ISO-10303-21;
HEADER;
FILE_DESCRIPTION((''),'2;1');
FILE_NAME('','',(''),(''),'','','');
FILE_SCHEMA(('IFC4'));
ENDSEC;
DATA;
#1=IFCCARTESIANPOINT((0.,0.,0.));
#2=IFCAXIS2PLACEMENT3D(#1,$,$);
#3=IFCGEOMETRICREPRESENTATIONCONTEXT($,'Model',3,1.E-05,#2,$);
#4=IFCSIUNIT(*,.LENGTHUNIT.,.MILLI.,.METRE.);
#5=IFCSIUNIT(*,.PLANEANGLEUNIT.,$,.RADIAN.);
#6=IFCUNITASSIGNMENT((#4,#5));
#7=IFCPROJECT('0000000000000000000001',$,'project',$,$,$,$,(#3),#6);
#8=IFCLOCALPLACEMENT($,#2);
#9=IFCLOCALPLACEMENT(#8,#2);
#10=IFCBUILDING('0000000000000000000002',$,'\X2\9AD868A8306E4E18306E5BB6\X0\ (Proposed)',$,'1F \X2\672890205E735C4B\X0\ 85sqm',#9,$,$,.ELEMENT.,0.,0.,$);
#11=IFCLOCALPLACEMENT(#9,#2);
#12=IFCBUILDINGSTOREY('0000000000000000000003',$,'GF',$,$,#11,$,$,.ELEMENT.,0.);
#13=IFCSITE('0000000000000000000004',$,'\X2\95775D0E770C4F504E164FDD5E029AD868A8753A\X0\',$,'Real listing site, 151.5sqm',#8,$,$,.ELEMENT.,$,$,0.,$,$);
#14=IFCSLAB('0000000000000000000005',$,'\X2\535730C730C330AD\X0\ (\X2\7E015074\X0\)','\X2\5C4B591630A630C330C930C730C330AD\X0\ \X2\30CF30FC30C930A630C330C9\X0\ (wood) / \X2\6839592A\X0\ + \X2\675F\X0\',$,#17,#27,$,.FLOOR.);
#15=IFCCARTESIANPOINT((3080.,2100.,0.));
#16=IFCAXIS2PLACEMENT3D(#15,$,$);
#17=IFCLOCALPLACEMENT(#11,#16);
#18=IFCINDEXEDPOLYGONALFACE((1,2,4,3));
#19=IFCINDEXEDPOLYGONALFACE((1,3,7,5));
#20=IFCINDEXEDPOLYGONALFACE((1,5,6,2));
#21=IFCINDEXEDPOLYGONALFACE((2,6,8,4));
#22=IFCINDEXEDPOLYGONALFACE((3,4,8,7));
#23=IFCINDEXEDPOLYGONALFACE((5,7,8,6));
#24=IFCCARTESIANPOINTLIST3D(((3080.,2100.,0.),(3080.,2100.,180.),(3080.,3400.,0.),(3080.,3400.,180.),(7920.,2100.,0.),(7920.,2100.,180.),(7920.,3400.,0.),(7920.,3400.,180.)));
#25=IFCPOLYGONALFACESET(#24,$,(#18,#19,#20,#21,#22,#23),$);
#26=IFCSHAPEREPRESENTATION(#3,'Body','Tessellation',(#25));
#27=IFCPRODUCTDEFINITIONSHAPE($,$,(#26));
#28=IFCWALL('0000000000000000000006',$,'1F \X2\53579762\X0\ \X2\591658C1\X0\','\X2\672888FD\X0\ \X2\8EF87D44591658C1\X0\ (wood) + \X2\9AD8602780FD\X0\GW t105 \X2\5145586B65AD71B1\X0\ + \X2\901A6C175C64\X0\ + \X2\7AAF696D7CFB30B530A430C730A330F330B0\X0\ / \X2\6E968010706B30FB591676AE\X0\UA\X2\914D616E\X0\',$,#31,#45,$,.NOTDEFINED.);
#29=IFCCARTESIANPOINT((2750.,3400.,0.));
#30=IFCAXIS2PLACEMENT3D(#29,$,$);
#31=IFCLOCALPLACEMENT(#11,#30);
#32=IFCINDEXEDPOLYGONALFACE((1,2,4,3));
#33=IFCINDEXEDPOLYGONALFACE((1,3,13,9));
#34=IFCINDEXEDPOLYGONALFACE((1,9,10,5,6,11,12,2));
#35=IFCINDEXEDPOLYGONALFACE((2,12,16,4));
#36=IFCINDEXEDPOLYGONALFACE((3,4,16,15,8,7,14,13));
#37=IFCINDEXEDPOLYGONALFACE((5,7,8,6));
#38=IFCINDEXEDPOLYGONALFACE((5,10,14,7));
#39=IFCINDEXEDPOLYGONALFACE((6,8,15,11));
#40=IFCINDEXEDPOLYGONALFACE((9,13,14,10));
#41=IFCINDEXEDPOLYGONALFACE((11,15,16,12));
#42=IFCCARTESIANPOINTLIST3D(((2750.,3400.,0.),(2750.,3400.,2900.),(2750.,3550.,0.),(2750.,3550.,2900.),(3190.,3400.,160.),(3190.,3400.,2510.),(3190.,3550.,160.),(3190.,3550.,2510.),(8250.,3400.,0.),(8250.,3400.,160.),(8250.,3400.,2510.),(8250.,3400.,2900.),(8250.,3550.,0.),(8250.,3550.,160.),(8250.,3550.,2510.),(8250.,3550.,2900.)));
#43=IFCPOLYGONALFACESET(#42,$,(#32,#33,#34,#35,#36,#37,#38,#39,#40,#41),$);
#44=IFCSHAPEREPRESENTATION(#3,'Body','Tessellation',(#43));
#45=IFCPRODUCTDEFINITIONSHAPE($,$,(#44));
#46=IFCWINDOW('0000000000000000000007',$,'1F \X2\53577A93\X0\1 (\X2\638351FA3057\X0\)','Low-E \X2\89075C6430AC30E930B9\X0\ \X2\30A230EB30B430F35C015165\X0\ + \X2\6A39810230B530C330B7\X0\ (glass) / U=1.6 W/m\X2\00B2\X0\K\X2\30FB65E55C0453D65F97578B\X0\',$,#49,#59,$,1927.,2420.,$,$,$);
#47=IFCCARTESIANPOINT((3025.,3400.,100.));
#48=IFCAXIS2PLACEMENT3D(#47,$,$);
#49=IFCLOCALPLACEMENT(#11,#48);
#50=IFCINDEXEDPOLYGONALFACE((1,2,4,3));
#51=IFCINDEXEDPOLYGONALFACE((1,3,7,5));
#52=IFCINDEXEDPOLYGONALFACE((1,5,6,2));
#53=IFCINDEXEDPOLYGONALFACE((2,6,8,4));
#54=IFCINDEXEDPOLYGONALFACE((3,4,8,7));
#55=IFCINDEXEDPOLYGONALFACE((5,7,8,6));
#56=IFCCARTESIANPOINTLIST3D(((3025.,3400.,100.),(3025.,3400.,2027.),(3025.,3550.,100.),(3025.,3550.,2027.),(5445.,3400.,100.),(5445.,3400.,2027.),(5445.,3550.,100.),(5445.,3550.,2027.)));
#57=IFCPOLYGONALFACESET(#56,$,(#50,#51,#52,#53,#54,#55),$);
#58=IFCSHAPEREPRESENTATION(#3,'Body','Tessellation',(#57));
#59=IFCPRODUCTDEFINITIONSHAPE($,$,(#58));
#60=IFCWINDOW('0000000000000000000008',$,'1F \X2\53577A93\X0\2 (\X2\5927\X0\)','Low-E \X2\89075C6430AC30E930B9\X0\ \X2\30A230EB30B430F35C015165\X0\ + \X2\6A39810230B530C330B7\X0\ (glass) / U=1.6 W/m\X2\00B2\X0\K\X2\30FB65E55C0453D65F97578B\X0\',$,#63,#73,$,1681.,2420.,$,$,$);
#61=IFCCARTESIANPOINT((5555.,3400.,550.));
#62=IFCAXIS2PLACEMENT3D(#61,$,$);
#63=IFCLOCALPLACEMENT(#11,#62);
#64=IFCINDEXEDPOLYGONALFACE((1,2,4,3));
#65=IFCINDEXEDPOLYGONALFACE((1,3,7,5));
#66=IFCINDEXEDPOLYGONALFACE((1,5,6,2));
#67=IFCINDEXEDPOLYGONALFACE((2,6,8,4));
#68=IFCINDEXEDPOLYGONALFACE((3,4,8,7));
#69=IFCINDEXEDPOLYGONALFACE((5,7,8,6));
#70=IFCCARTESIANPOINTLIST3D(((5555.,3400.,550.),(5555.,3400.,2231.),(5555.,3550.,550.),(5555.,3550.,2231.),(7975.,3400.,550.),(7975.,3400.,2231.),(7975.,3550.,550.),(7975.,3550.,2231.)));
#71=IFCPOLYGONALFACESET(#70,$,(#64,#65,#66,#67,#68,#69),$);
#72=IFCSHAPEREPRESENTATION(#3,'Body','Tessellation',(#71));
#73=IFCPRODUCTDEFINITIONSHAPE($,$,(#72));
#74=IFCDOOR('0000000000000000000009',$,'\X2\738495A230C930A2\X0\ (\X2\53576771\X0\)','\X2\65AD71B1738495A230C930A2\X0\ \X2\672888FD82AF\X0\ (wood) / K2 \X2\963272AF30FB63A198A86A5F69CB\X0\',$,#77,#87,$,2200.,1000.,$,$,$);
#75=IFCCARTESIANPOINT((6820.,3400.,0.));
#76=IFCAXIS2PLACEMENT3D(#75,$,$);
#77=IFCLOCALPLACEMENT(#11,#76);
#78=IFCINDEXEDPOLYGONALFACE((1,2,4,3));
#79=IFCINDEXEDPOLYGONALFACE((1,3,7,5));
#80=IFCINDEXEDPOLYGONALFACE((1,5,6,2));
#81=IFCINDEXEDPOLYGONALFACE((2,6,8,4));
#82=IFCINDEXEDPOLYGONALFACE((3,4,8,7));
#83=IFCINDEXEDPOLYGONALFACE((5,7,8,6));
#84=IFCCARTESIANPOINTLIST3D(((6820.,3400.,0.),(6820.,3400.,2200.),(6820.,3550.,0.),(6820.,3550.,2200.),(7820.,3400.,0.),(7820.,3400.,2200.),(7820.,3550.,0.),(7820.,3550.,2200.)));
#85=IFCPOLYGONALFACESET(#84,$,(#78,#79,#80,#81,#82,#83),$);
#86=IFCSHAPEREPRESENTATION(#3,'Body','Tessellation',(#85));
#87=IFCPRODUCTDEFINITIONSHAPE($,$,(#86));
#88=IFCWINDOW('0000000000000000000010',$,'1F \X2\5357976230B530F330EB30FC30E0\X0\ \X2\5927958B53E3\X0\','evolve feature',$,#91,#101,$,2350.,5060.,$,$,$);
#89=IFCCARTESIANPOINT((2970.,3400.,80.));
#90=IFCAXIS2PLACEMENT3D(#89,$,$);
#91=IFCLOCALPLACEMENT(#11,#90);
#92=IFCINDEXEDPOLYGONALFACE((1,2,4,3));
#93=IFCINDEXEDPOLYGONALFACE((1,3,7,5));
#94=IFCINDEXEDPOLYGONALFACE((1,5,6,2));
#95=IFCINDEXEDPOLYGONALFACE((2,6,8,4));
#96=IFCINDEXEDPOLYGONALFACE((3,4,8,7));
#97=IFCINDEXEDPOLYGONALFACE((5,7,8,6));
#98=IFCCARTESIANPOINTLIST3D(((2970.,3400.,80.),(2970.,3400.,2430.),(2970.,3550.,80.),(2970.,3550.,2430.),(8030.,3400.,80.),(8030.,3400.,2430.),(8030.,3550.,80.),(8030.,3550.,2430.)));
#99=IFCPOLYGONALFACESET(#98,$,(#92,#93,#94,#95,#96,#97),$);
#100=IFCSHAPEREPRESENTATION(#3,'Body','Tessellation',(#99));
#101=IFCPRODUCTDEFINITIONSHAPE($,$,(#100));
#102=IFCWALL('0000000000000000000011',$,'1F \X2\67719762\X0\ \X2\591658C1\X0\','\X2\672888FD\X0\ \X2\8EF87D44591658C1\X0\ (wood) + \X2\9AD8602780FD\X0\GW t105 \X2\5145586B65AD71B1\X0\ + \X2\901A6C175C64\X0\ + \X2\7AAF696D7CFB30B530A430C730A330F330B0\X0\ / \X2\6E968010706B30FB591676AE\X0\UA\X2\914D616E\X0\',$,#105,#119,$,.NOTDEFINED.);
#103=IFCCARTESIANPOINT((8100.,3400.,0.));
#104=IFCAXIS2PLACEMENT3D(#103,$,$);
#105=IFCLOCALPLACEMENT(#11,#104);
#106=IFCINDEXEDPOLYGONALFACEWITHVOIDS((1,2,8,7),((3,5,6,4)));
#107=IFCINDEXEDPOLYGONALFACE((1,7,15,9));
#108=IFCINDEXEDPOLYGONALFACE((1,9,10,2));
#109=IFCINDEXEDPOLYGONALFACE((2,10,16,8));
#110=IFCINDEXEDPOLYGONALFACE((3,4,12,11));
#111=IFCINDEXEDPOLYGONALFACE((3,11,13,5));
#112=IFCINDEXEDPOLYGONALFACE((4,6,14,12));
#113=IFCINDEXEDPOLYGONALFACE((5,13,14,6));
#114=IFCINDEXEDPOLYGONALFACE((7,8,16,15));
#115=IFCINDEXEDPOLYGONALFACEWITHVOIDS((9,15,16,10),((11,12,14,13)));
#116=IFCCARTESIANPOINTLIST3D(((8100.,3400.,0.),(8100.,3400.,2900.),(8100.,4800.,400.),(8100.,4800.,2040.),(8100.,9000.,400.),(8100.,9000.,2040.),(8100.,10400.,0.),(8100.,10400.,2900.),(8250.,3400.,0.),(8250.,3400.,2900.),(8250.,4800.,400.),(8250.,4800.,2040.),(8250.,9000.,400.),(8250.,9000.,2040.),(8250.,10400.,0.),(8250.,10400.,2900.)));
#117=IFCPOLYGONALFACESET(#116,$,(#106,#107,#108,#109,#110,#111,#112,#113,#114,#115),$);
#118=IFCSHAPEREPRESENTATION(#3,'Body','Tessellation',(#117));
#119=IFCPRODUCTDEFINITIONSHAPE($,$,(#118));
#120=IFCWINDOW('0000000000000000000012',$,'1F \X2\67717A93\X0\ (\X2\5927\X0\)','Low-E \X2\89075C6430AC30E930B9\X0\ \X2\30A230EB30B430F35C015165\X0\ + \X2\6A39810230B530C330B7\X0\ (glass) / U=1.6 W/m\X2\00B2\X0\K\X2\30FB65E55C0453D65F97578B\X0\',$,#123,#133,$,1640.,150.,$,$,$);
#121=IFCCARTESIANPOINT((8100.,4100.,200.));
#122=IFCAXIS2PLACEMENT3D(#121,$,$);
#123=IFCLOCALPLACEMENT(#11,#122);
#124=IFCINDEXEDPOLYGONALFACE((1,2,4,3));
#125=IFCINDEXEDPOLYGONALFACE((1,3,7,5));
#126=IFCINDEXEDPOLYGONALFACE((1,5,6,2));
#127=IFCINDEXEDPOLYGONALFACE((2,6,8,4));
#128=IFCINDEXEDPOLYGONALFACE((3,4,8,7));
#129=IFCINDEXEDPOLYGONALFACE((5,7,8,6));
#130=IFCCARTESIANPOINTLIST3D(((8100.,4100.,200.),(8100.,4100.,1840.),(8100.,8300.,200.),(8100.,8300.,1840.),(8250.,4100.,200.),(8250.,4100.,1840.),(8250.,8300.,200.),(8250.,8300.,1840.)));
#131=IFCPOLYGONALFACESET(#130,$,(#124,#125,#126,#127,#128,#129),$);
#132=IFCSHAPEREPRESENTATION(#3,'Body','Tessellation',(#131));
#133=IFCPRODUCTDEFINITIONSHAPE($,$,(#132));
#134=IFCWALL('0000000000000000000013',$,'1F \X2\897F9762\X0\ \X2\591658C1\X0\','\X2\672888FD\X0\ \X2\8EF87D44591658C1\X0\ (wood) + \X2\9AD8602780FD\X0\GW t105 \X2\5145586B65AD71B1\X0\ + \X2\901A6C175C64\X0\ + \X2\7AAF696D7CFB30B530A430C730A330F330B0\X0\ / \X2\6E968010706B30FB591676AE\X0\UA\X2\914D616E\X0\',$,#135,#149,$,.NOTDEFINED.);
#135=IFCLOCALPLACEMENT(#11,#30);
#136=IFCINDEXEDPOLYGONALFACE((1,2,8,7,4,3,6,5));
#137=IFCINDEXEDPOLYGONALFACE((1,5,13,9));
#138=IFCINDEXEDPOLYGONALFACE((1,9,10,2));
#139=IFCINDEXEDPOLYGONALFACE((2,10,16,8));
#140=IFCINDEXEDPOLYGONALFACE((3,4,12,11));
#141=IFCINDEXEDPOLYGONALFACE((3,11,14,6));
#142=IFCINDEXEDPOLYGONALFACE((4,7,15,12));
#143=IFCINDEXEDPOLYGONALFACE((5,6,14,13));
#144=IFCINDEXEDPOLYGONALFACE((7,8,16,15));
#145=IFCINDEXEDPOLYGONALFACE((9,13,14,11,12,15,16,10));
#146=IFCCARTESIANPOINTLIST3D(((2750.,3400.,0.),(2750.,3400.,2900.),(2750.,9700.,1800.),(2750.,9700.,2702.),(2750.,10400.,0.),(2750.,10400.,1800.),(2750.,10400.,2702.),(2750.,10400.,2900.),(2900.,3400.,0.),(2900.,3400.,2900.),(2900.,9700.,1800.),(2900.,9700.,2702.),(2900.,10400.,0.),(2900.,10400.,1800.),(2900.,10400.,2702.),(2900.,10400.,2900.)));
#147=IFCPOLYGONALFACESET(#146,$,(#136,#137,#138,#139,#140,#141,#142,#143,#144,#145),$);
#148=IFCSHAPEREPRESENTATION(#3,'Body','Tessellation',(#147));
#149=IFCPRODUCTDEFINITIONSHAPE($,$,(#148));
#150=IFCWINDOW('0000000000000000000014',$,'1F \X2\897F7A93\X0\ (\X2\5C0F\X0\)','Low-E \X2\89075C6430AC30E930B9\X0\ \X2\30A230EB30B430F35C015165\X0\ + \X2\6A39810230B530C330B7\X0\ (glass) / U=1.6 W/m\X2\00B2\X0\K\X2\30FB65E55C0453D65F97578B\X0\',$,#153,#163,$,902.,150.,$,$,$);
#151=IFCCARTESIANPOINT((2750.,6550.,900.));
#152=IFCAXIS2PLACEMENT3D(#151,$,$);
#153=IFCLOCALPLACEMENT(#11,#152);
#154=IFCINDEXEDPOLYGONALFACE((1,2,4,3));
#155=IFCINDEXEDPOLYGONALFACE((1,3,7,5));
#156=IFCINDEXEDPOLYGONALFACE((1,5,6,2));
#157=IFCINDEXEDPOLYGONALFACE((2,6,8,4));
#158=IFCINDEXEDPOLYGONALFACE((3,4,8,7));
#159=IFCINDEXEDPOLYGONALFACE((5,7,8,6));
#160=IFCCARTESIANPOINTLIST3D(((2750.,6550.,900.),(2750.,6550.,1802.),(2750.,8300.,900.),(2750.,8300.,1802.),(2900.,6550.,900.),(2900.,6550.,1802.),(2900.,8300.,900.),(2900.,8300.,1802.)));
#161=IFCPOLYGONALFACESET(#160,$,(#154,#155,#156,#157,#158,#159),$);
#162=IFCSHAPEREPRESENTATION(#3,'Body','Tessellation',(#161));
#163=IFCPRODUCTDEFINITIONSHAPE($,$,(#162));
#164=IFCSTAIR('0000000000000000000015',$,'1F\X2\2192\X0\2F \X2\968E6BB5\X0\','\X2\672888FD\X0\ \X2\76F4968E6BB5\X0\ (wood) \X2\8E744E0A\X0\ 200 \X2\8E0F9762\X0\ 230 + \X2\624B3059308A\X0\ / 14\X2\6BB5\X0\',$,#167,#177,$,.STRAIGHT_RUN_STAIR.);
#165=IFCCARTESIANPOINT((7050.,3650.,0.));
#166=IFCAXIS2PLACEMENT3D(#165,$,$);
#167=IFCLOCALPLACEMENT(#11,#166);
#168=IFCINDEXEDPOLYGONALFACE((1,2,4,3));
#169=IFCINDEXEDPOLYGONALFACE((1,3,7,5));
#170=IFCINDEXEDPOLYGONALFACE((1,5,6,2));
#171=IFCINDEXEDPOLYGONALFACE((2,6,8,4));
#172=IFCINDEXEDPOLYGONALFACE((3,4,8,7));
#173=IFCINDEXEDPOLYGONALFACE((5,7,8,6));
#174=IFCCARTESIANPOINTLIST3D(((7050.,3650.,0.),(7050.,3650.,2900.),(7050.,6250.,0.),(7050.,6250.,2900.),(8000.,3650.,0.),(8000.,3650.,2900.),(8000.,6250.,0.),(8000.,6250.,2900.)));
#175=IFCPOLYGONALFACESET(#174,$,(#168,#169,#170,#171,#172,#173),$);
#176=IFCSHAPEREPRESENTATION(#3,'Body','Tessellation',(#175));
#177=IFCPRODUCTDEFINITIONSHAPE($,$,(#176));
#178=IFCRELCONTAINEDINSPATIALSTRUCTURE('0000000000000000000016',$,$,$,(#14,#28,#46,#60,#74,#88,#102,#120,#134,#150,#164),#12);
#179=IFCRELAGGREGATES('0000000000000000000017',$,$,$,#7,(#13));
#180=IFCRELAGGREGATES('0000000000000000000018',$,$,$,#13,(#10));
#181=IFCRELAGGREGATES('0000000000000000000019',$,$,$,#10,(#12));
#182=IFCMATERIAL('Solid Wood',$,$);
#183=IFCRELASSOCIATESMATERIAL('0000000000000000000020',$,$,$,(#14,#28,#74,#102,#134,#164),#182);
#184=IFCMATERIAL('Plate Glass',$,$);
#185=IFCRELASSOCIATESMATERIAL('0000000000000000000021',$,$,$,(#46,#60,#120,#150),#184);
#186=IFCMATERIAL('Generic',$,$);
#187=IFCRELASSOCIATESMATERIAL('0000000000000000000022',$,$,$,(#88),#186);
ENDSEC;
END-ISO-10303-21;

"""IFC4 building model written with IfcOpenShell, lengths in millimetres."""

from ifc_helpers import new_model, si_unit, frame, frame_2d, origin, place, context, project, spatial, rectangle, extrude, material, element, fill, save


model = new_model("IFC4")

# Units and contexts
model_context = context("Model", 3, precision=1e-05, world=origin())
ifc_project = project(units=[si_unit("LENGTHUNIT", "METRE", prefix="MILLI"), si_unit("PLANEANGLEUNIT", "RADIAN")], contexts=[model_context])

# Site, building, storey
site_placement = place(None, origin())
site = spatial("IfcSite", under=ifc_project, at=site_placement, Name="長崎県佐世保市高梨町", ObjectType="Real listing site, 151.5sqm", CompositionType="ELEMENT", RefElevation=0.0)
building_placement = place(site_placement, origin())
building = spatial("IfcBuilding", under=site, at=building_placement, Name="高梨の丘の家 (Proposed)", ObjectType="1F 木造平屋 85sqm", CompositionType="ELEMENT", ElevationOfRefHeight=0.0, ElevationOfTerrain=0.0)
storey_placement = place(building_placement, origin())
storey = spatial("IfcBuildingStorey", under=building, at=storey_placement, Name="GF", CompositionType="ELEMENT", Elevation=0.0)

# Slab
ifc_material_1 = material(Name="Solid Wood")
slab_1_placement = place(storey_placement, frame((3080.0, 2100.0, 0.0)))
element("IfcSlab", 1, at=slab_1_placement, inside=storey, material=ifc_material_1, Name="南デッキ (縁側)", Description="屋外ウッドデッキ ハードウッド (wood) / 根太 + 束", PredefinedType="FLOOR", context=model_context, shape_type="SweptSolid", body=[
    extrude(rectangle(XDim=4840.0, YDim=1300.0, at=frame_2d((2420.0, 650.0))), frame((3080.0, 2100.0, 0.0)), (0.0, 0.0, 1.0), 180.0),
])
ifc_material_2 = material(Name="Generic")

# Wall, openings, windows, door
wall_1_placement = place(storey_placement, frame((2750.0, 3400.0, 0.0)))
wall_1 = element("IfcWall", 2, at=wall_1_placement, inside=storey, material=ifc_material_1, Name="1F 南面 外壁", Description="木製 軸組外壁 (wood) + 高性能GW t105 充填断熱 + 通気層 + 窯業系サイディング / 準耐火・外皮UA配慮", PredefinedType="NOTDEFINED", context=model_context, shape_type="SweptSolid", body=[
    extrude(rectangle(XDim=5500.0, YDim=150.0, at=frame_2d((2750.0, 75.0))), frame((2750.0, 3400.0, 0.0)), (0.0, 0.0, 1.0), 2900.0),
])
opening_1_placement = place(storey_placement, frame((3025.0, 3400.0, 100.0)))
opening_1 = element("IfcOpeningElement", 3, at=opening_1_placement, cuts=wall_1, PredefinedType="NOTDEFINED", context=model_context, shape_type="SweptSolid", body=[
    extrude(rectangle(XDim=2420.0, YDim=150.0, at=frame_2d((1210.0, 75.0))), frame((3025.0, 3400.0, 100.0)), (0.0, 0.0, 1.0), 1927.0),
])
opening_2_placement = place(storey_placement, frame((5555.0, 3400.0, 550.0)))
opening_2 = element("IfcOpeningElement", 4, at=opening_2_placement, cuts=wall_1, PredefinedType="NOTDEFINED", context=model_context, shape_type="SweptSolid", body=[
    extrude(rectangle(XDim=2420.0, YDim=150.0, at=frame_2d((1210.0, 75.0))), frame((5555.0, 3400.0, 550.0)), (0.0, 0.0, 1.0), 1681.0),
])
opening_3_placement = place(storey_placement, frame((6820.0, 3400.0, 0.0)))
opening_3 = element("IfcOpeningElement", 5, at=opening_3_placement, cuts=wall_1, PredefinedType="NOTDEFINED", context=model_context, shape_type="SweptSolid", body=[
    extrude(rectangle(XDim=1000.0, YDim=150.0, at=frame_2d((500.0, 75.0))), frame((6820.0, 3400.0, 0.0)), (0.0, 0.0, 1.0), 2200.0),
])
opening_4_placement = place(storey_placement, frame((2970.0, 3400.0, 80.0)))
opening_4 = element("IfcOpeningElement", 6, at=opening_4_placement, cuts=wall_1, PredefinedType="NOTDEFINED", context=model_context, shape_type="SweptSolid", body=[
    extrude(rectangle(XDim=5060.0, YDim=150.0, at=frame_2d((2530.0, 75.0))), frame((2970.0, 3400.0, 80.0)), (0.0, 0.0, 1.0), 2350.0),
])
ifc_material_3 = material(Name="Plate Glass")
window_1_placement = place(storey_placement, frame((3025.0, 3400.0, 100.0)))
window_1 = element("IfcWindow", 7, at=window_1_placement, inside=storey, material=ifc_material_3, Name="1F 南窓1 (掃出し)", Description="Low-E 複層ガラス アルゴン封入 + 樹脂サッシ (glass) / U=1.6 W/m²K・日射取得型", OverallHeight=1927.0, OverallWidth=2420.0, context=model_context, shape_type="SweptSolid", body=[
    extrude(rectangle(XDim=2420.0, YDim=150.0, at=frame_2d((1210.0, 75.0))), frame((3025.0, 3400.0, 100.0)), (0.0, 0.0, 1.0), 1927.0),
])
fill(opening_1, window_1)
window_2_placement = place(storey_placement, frame((5555.0, 3400.0, 550.0)))
window_2 = element("IfcWindow", 8, at=window_2_placement, inside=storey, material=ifc_material_3, Name="1F 南窓2 (大)", Description="Low-E 複層ガラス アルゴン封入 + 樹脂サッシ (glass) / U=1.6 W/m²K・日射取得型", OverallHeight=1681.0, OverallWidth=2420.0, context=model_context, shape_type="SweptSolid", body=[
    extrude(rectangle(XDim=2420.0, YDim=150.0, at=frame_2d((1210.0, 75.0))), frame((5555.0, 3400.0, 550.0)), (0.0, 0.0, 1.0), 1681.0),
])
fill(opening_2, window_2)
door_placement = place(storey_placement, frame((6820.0, 3400.0, 0.0)))
door = element("IfcDoor", 9, at=door_placement, inside=storey, material=ifc_material_1, Name="玄関ドア (南東)", Description="断熱玄関ドア 木製芯 (wood) / K2 防犯・採風機構", OverallHeight=2200.0, OverallWidth=1000.0, context=model_context, shape_type="SweptSolid", body=[
    extrude(rectangle(XDim=1000.0, YDim=150.0, at=frame_2d((500.0, 75.0))), frame((6820.0, 3400.0, 0.0)), (0.0, 0.0, 1.0), 2200.0),
])
fill(opening_3, door)
window_3_placement = place(storey_placement, frame((2970.0, 3400.0, 80.0)))
window_3 = element("IfcWindow", 10, at=window_3_placement, inside=storey, material=ifc_material_2, Name="1F 南面サンルーム 大開口", Description="evolve feature", OverallHeight=2350.0, OverallWidth=5060.0, context=model_context, shape_type="SweptSolid", body=[
    extrude(rectangle(XDim=5060.0, YDim=150.0, at=frame_2d((2530.0, 75.0))), frame((2970.0, 3400.0, 80.0)), (0.0, 0.0, 1.0), 2350.0),
])
fill(opening_4, window_3)

# Walls, openings, windows
wall_2_placement = place(storey_placement, frame((8100.0, 3400.0, 0.0)))
wall_2 = element("IfcWall", 11, at=wall_2_placement, inside=storey, material=ifc_material_1, Name="1F 東面 外壁", Description="木製 軸組外壁 (wood) + 高性能GW t105 充填断熱 + 通気層 + 窯業系サイディング / 準耐火・外皮UA配慮", PredefinedType="NOTDEFINED", context=model_context, shape_type="SweptSolid", body=[
    extrude(rectangle(XDim=150.0, YDim=7000.0, at=frame_2d((75.0, 3500.0))), frame((8100.0, 3400.0, 0.0)), (0.0, 0.0, 1.0), 2900.0),
])
opening_5_placement = place(storey_placement, frame((8100.0, 4100.0, 200.0)))
opening_5 = element("IfcOpeningElement", 12, at=opening_5_placement, cuts=wall_2, PredefinedType="NOTDEFINED", context=model_context, shape_type="SweptSolid", body=[
    extrude(rectangle(XDim=150.0, YDim=4200.0, at=frame_2d((75.0, 2100.0))), frame((8100.0, 4100.0, 200.0)), (0.0, 0.0, 1.0), 1640.0),
])
window_4_placement = place(storey_placement, frame((8100.0, 4100.0, 200.0)))
window_4 = element("IfcWindow", 13, at=window_4_placement, inside=storey, material=ifc_material_3, Name="1F 東窓 (大)", Description="Low-E 複層ガラス アルゴン封入 + 樹脂サッシ (glass) / U=1.6 W/m²K・日射取得型", OverallHeight=1640.0, OverallWidth=150.0, context=model_context, shape_type="SweptSolid", body=[
    extrude(rectangle(XDim=150.0, YDim=4200.0, at=frame_2d((75.0, 2100.0))), frame((8100.0, 4100.0, 200.0)), (0.0, 0.0, 1.0), 1640.0),
])
fill(opening_5, window_4)
wall_3_placement = place(storey_placement, frame((2750.0, 3400.0, 0.0)))
wall_3 = element("IfcWall", 14, at=wall_3_placement, inside=storey, material=ifc_material_1, Name="1F 西面 外壁", Description="木製 軸組外壁 (wood) + 高性能GW t105 充填断熱 + 通気層 + 窯業系サイディング / 準耐火・外皮UA配慮", PredefinedType="NOTDEFINED", context=model_context, shape_type="SweptSolid", body=[
    extrude(rectangle(XDim=150.0, YDim=7000.0, at=frame_2d((75.0, 3500.0))), frame((2750.0, 3400.0, 0.0)), (0.0, 0.0, 1.0), 2900.0),
])
opening_6_placement = place(storey_placement, frame((2750.0, 6550.0, 900.0)))
opening_6 = element("IfcOpeningElement", 15, at=opening_6_placement, cuts=wall_3, PredefinedType="NOTDEFINED", context=model_context, shape_type="SweptSolid", body=[
    extrude(rectangle(XDim=150.0, YDim=1750.0, at=frame_2d((75.0, 875.0))), frame((2750.0, 6550.0, 900.0)), (0.0, 0.0, 1.0), 902.0),
])
window_5_placement = place(storey_placement, frame((2750.0, 6550.0, 900.0)))
window_5 = element("IfcWindow", 16, at=window_5_placement, inside=storey, material=ifc_material_3, Name="1F 西窓 (小)", Description="Low-E 複層ガラス アルゴン封入 + 樹脂サッシ (glass) / U=1.6 W/m²K・日射取得型", OverallHeight=902.0, OverallWidth=150.0, context=model_context, shape_type="SweptSolid", body=[
    extrude(rectangle(XDim=150.0, YDim=1750.0, at=frame_2d((75.0, 875.0))), frame((2750.0, 6550.0, 900.0)), (0.0, 0.0, 1.0), 902.0),
])
fill(opening_6, window_5)

# Stair
stair_placement = place(storey_placement, frame((7050.0, 3650.0, 0.0)))
element("IfcStair", 17, at=stair_placement, inside=storey, material=ifc_material_1, Name="1F→2F 階段", Description="木製 直階段 (wood) 蹴上 200 踏面 230 + 手すり / 14段", PredefinedType="STRAIGHT_RUN_STAIR", context=model_context, shape_type="SweptSolid", body=[
    extrude(rectangle(XDim=950.0, YDim=2600.0, at=frame_2d((475.0, 1300.0))), frame((7050.0, 3650.0, 0.0)), (0.0, 0.0, 1.0), 2900.0),
])

save(model, "model.ifc")
